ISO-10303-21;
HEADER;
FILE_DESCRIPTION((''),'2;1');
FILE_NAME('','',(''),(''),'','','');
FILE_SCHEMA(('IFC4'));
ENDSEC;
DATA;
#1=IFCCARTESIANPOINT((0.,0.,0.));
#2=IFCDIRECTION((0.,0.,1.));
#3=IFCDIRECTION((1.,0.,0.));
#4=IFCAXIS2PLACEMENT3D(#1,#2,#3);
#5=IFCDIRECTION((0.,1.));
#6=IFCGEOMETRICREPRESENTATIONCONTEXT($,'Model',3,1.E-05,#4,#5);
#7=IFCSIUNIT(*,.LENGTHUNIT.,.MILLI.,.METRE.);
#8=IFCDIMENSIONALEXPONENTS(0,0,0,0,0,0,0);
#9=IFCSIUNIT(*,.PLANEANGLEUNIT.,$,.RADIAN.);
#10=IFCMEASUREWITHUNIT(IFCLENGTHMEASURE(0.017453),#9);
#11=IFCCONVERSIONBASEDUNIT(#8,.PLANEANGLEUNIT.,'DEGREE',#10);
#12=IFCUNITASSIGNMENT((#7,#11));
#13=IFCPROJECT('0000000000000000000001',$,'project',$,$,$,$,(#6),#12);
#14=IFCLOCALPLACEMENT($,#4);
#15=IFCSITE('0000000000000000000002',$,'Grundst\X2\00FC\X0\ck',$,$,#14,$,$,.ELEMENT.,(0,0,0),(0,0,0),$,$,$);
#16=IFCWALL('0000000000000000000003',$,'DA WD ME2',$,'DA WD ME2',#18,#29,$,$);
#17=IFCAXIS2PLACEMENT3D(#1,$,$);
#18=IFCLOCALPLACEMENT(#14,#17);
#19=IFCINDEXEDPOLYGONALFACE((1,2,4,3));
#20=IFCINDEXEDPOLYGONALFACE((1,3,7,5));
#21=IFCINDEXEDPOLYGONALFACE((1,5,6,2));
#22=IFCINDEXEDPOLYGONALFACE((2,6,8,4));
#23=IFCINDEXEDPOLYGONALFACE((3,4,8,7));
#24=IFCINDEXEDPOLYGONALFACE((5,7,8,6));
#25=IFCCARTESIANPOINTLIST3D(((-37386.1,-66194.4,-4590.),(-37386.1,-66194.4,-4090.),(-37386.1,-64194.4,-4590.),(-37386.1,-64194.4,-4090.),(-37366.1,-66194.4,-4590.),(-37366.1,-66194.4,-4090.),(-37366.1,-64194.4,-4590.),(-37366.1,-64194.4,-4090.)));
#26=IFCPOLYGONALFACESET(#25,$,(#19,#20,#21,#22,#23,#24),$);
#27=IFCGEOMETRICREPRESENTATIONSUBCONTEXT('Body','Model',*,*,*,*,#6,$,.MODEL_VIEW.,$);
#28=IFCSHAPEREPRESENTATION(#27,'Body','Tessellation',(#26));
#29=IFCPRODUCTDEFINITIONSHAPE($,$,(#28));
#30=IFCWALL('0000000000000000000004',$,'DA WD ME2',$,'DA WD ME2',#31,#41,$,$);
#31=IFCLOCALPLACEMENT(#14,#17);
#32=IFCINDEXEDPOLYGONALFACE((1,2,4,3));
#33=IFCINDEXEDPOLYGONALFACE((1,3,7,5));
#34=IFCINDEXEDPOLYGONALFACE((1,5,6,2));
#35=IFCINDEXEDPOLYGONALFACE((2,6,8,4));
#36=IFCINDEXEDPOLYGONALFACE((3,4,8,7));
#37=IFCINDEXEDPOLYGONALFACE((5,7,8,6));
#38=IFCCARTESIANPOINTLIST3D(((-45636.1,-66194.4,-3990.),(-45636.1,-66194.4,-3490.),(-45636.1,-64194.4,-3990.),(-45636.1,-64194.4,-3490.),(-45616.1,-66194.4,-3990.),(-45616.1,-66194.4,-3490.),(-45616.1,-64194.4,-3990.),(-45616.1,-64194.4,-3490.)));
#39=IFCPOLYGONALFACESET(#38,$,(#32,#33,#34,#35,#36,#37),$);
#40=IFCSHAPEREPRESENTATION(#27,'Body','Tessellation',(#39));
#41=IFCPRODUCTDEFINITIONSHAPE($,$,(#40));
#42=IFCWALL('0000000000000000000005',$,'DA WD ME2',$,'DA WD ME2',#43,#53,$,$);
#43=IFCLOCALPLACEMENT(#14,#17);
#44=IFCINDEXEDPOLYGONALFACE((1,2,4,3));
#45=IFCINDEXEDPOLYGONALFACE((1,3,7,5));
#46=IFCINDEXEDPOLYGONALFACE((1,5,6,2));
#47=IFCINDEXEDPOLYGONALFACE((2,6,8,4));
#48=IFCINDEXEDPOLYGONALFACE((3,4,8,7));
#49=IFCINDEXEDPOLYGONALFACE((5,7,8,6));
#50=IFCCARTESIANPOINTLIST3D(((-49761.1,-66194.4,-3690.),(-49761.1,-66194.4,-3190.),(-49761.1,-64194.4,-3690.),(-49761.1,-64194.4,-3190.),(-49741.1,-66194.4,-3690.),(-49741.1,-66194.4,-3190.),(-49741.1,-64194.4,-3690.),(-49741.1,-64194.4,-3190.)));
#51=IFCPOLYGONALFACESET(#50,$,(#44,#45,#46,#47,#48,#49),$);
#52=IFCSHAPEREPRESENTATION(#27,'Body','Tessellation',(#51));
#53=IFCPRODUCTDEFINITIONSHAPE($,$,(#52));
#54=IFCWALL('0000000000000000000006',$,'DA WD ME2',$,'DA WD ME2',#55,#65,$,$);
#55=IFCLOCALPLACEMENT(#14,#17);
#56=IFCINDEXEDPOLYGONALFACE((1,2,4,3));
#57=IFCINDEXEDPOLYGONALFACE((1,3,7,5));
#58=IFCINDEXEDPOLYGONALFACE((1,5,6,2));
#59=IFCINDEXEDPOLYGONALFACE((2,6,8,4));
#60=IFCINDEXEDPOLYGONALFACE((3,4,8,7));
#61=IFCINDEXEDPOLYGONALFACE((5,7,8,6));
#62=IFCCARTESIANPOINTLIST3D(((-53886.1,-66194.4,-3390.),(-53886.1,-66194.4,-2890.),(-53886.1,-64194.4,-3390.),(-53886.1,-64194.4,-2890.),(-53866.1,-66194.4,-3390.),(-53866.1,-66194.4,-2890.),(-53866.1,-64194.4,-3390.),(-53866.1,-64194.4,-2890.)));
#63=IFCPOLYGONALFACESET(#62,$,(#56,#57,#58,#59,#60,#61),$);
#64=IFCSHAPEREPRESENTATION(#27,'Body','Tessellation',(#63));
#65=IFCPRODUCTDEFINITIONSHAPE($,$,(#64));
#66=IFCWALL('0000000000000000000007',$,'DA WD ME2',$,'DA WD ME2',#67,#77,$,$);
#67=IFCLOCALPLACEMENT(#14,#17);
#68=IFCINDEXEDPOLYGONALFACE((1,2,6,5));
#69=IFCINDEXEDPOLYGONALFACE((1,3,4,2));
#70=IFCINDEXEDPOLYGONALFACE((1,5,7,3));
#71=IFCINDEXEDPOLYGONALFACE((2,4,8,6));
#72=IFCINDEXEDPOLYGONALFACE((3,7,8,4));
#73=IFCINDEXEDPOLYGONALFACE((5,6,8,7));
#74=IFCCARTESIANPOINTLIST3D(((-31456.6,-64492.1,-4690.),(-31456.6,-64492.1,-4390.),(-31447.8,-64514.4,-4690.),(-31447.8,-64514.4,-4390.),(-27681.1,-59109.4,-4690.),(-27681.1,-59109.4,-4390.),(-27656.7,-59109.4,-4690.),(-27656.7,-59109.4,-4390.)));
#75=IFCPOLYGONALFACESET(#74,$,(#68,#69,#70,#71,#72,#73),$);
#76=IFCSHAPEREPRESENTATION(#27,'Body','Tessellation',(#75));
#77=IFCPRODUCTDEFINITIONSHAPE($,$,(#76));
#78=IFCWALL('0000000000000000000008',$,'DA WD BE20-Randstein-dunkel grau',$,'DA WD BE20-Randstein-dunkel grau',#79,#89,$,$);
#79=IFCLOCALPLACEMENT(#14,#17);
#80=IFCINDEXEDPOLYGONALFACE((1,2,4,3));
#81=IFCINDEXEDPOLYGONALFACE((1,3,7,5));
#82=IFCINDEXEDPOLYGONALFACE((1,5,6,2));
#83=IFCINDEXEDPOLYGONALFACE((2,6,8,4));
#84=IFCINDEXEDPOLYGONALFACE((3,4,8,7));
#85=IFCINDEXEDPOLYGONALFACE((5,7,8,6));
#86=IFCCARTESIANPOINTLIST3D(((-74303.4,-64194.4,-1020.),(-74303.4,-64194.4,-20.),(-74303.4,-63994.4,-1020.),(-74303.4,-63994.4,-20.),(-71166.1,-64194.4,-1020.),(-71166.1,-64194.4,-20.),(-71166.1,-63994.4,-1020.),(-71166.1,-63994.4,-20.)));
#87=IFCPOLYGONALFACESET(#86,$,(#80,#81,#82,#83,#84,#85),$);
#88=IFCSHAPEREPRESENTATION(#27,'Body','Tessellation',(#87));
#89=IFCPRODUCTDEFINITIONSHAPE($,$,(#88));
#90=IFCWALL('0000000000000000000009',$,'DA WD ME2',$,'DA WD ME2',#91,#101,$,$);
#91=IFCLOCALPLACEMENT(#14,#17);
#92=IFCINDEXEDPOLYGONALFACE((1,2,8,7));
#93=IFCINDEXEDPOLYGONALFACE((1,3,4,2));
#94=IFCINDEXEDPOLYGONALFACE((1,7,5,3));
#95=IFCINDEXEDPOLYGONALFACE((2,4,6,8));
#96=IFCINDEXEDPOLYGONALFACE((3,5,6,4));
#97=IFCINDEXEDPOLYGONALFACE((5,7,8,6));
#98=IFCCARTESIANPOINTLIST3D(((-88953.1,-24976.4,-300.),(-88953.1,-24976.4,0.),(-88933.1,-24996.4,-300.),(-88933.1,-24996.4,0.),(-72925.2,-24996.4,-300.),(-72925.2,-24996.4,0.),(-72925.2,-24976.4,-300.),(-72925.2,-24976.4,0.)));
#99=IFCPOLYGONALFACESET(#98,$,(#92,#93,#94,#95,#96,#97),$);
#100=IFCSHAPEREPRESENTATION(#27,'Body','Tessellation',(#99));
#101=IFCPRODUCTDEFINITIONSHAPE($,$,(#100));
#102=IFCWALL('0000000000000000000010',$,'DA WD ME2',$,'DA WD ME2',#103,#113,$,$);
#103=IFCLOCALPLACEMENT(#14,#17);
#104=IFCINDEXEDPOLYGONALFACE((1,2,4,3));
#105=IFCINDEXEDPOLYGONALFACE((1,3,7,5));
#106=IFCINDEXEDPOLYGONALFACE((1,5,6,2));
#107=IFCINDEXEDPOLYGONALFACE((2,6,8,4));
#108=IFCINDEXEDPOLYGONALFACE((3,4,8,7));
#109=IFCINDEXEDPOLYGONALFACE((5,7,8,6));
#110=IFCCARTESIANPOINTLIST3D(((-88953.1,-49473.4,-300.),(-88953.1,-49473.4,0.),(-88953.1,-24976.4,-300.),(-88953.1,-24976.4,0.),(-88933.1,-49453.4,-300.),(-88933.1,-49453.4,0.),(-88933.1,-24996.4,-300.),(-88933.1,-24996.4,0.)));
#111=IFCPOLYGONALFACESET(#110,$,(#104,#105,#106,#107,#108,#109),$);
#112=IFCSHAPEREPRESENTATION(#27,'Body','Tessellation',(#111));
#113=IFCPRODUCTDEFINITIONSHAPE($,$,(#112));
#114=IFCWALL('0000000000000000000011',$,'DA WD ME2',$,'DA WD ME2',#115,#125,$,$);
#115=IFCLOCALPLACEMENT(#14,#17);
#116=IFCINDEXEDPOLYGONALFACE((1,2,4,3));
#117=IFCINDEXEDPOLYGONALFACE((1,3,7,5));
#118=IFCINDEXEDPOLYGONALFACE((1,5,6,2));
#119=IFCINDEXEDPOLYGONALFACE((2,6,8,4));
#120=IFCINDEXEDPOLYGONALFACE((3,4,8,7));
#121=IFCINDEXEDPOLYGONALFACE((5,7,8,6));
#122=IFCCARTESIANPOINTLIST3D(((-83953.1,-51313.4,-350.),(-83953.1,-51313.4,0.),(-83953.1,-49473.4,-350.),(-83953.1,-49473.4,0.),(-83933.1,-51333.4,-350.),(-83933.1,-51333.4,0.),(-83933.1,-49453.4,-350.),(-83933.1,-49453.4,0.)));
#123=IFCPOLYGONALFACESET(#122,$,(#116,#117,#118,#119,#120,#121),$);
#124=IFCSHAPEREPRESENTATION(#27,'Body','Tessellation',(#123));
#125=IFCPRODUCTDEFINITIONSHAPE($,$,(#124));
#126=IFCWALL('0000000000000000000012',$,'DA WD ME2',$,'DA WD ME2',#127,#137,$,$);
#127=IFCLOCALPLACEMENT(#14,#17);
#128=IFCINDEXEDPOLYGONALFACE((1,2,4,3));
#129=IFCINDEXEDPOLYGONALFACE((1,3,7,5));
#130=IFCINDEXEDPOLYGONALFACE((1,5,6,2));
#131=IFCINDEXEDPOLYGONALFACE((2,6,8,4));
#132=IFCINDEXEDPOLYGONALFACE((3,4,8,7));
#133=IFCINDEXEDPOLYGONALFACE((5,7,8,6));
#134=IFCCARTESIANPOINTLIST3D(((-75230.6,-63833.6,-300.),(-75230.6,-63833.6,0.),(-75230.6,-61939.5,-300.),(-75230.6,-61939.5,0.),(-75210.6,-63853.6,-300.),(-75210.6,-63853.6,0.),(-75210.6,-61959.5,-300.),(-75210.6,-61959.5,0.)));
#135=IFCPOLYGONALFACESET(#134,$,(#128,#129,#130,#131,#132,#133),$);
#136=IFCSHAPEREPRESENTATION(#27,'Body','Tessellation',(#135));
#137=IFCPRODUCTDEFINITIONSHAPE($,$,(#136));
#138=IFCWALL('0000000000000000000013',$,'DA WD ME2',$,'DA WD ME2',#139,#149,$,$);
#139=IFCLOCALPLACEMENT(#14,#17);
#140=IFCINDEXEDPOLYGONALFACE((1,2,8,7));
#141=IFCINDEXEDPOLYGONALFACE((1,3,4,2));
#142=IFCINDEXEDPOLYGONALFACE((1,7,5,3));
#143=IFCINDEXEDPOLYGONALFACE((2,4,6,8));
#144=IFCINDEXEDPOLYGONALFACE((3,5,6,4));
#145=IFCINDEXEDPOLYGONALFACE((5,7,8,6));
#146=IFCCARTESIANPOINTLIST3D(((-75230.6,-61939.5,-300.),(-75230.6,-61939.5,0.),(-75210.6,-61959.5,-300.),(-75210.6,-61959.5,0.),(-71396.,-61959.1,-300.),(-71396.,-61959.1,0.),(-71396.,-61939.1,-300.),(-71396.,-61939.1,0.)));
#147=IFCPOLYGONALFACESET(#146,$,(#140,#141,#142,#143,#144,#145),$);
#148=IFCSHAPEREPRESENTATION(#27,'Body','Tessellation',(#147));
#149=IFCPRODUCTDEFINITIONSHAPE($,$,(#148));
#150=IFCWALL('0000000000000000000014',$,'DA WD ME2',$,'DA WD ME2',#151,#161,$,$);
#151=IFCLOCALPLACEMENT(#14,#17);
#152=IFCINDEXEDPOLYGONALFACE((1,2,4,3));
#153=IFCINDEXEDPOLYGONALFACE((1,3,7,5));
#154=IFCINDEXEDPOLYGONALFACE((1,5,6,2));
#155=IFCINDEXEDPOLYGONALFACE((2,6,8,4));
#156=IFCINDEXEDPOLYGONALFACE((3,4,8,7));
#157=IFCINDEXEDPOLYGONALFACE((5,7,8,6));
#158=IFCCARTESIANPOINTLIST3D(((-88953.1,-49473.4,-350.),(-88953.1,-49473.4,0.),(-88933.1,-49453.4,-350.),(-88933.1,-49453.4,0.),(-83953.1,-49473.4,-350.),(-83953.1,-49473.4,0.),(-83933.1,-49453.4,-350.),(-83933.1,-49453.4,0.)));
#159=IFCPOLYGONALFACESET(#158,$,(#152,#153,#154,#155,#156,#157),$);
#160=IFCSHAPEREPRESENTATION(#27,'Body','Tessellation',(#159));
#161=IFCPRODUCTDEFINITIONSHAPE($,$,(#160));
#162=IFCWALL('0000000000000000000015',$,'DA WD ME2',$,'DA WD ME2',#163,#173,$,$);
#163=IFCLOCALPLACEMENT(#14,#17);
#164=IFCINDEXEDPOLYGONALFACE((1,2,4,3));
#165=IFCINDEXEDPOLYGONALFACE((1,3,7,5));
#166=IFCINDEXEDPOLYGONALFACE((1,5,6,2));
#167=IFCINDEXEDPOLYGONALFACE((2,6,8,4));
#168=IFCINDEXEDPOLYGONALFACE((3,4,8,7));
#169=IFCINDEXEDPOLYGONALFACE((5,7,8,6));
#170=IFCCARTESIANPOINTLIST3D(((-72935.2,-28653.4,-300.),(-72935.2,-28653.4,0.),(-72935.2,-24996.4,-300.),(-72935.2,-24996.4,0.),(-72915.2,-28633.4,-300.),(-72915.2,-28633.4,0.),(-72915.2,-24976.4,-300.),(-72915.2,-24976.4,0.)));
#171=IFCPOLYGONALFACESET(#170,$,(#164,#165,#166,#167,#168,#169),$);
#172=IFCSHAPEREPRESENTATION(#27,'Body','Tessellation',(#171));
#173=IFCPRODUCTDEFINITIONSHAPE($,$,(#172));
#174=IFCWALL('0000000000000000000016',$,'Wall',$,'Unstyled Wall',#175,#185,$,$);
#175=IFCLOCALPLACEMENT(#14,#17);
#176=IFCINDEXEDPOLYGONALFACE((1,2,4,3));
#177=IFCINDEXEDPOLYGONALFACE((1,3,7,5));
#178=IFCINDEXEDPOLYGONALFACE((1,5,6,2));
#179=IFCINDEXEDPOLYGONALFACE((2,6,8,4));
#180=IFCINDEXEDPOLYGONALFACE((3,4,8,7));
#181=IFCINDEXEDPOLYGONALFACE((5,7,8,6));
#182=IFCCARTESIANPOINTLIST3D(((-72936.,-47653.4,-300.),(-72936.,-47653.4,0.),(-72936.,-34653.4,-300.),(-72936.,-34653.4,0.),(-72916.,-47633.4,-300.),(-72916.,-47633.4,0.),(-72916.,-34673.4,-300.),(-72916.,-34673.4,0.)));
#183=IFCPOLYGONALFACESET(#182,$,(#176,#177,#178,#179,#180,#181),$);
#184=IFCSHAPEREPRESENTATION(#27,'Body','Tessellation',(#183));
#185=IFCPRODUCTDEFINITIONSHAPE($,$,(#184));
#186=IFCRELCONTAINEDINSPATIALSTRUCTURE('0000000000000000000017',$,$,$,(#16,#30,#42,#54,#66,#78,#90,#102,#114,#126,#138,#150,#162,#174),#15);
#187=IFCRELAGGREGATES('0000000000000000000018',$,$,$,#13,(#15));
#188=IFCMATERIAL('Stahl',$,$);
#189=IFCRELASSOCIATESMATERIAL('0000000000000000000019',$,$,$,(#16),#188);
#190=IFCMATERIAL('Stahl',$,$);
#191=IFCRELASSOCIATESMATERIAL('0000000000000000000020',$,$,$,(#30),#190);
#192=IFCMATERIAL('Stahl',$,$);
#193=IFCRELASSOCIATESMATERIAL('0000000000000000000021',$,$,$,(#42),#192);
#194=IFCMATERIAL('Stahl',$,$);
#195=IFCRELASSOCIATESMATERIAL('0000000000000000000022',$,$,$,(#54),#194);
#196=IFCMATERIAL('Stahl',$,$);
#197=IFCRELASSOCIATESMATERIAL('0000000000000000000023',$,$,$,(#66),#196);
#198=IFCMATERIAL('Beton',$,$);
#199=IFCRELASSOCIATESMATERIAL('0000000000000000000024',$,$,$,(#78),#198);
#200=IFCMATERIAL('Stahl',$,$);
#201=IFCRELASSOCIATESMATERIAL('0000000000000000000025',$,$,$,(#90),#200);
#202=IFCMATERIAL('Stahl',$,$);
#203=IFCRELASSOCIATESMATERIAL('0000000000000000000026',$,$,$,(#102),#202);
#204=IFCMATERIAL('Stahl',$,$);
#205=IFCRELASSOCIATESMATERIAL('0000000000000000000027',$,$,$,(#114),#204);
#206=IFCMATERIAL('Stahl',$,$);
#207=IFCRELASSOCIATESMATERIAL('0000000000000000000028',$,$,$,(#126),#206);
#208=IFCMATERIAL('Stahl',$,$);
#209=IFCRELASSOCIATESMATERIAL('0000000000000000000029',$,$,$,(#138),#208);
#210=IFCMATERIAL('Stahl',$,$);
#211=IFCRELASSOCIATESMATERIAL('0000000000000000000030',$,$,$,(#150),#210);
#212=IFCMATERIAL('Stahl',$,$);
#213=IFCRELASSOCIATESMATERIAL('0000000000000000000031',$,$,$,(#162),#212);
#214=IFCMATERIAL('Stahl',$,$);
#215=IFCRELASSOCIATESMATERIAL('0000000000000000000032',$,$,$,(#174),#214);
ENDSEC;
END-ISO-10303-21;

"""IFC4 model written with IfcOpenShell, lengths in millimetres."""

from ifc_helpers import new_model, entity, si_unit, converted_unit, direction, frame, origin_with_axes, place, context, subcontext, project, spatial, line, indexed_curve, outline, extrude, material, element, save


model = new_model("IFC4")

# Units and contexts
model_context = context("Model", 3, precision=1e-05, world=origin_with_axes(), true_north=direction((0.0, 1.0)))
body_context = subcontext(model_context, "Body", "Model", "MODEL_VIEW")
ifc_project = project(units=[si_unit("LENGTHUNIT", "METRE", prefix="MILLI"), converted_unit("PLANEANGLEUNIT", "DEGREE", entity("IfcLengthMeasure", 0.017453), si_unit("PLANEANGLEUNIT", "RADIAN"), dimensions=[0, 0, 0, 0, 0, 0, 0])], contexts=[model_context])

# Site
site_placement = place(None, origin_with_axes())
site = spatial("IfcSite", under=ifc_project, at=site_placement, Name="Grundstück", CompositionType="ELEMENT", RefLatitude=(0, 0, 0), RefLongitude=(0, 0, 0))

# Walls
ifc_material_1 = material(Name="Stahl")
wall_1_placement = place(site_placement, frame((-37376.1, -64194.4, -4590.0), z_axis=(0.0, 0.0, 1.0), x_axis=(0.0, -1.0, 0.0)))
element("IfcWall", 1, at=wall_1_placement, inside=site, material=ifc_material_1, Name="DA WD ME2", ObjectType="DA WD ME2", context=body_context, shape_type="SweptSolid", body=[
    extrude(outline(indexed_curve([(0.0, -10.0), (0.0, 10.0), (2000.0, 10.0), (2000.0, -10.0)], segments=[line(1, 2), line(2, 3), line(3, 4), line(4, 1)])), origin_with_axes(), (0.0, 0.0, 1.0), 500.0),
])
ifc_material_2 = material(Name="Stahl")
wall_2_placement = place(site_placement, frame((-45626.1, -64194.4, -3990.0), z_axis=(0.0, 0.0, 1.0), x_axis=(0.0, -1.0, 0.0)))
element("IfcWall", 2, at=wall_2_placement, inside=site, material=ifc_material_2, Name="DA WD ME2", ObjectType="DA WD ME2", context=body_context, shape_type="SweptSolid", body=[
    extrude(outline(indexed_curve([(0.0, -10.0), (0.0, 10.0), (2000.0, 10.0), (2000.0, -10.0)], segments=[line(1, 2), line(2, 3), line(3, 4), line(4, 1)])), origin_with_axes(), (0.0, 0.0, 1.0), 500.0),
])
ifc_material_3 = material(Name="Stahl")
wall_3_placement = place(site_placement, frame((-49751.1, -64194.4, -3690.0), z_axis=(0.0, 0.0, 1.0), x_axis=(0.0, -1.0, 0.0)))
element("IfcWall", 3, at=wall_3_placement, inside=site, material=ifc_material_3, Name="DA WD ME2", ObjectType="DA WD ME2", context=body_context, shape_type="SweptSolid", body=[
    extrude(outline(indexed_curve([(0.0, -10.0), (0.0, 10.0), (2000.0, 10.0), (2000.0, -10.0)], segments=[line(1, 2), line(2, 3), line(3, 4), line(4, 1)])), origin_with_axes(), (0.0, 0.0, 1.0), 500.0),
])
ifc_material_4 = material(Name="Stahl")
wall_4_placement = place(site_placement, frame((-53876.1, -64194.4, -3390.0), z_axis=(0.0, 0.0, 1.0), x_axis=(0.0, -1.0, 0.0)))
element("IfcWall", 4, at=wall_4_placement, inside=site, material=ifc_material_4, Name="DA WD ME2", ObjectType="DA WD ME2", context=body_context, shape_type="SweptSolid", body=[
    extrude(outline(indexed_curve([(0.0, -10.0), (0.0, 10.0), (2000.0, 10.0), (2000.0, -10.0)], segments=[line(1, 2), line(2, 3), line(3, 4), line(4, 1)])), origin_with_axes(), (0.0, 0.0, 1.0), 500.0),
])
ifc_material_5 = material(Name="Stahl")
wall_5_placement = place(site_placement, frame((-31452.2, -64503.3, -4690.0), z_axis=(0.0, 0.0, 1.0), x_axis=(0.574238, 0.818689, 0.0)))
element("IfcWall", 5, at=wall_5_placement, inside=site, material=ifc_material_5, Name="DA WD ME2", ObjectType="DA WD ME2", context=body_context, shape_type="SweptSolid", body=[
    extrude(outline(indexed_curve([(-6.6, -10.0), (6.6, 10.0), (6581.4, 10.0), (6595.4, -10.0)], segments=[line(1, 2), line(2, 3), line(3, 4), line(4, 1)])), origin_with_axes(), (0.0, 0.0, 1.0), 300.0),
])
ifc_material_6 = material(Name="Beton")
wall_6_placement = place(site_placement, frame((-74303.4, -64094.4, -1020.0), z_axis=(0.0, 0.0, 1.0), x_axis=(1.0, -0.000018, 0.0)))
element("IfcWall", 6, at=wall_6_placement, inside=site, material=ifc_material_6, Name="DA WD BE20-Randstein-dunkel grau", ObjectType="DA WD BE20-Randstein-dunkel grau", context=body_context, shape_type="SweptSolid", body=[
    extrude(outline(indexed_curve([(0.0, 100.0), (0.0, -100.0), (3137.3, -100.0), (3137.3, 100.0)], segments=[line(1, 2), line(2, 3), line(3, 4), line(4, 1)])), origin_with_axes(), (0.0, 0.0, 1.0), 1000.0),
])
ifc_material_7 = material(Name="Stahl")
wall_7_placement = place(site_placement, frame((-72925.2, -24986.4, -300.0), z_axis=(0.0, 0.0, 1.0), x_axis=(-1.0, 0.0, 0.0)))
element("IfcWall", 7, at=wall_7_placement, inside=site, material=ifc_material_7, Name="DA WD ME2", ObjectType="DA WD ME2", context=body_context, shape_type="SweptSolid", body=[
    extrude(outline(indexed_curve([(0.0, -10.0), (0.0, 10.0), (16007.8, 10.0), (16027.8, -10.0)], segments=[line(1, 2), line(2, 3), line(3, 4), line(4, 1)])), origin_with_axes(), (0.0, 0.0, 1.0), 300.0),
])
ifc_material_8 = material(Name="Stahl")
wall_8_placement = place(site_placement, frame((-88943.1, -24986.4, -300.0), z_axis=(0.0, 0.0, 1.0), x_axis=(0.0, -1.0, 0.0)))
element("IfcWall", 8, at=wall_8_placement, inside=site, material=ifc_material_8, Name="DA WD ME2", ObjectType="DA WD ME2", context=body_context, shape_type="SweptSolid", body=[
    extrude(outline(indexed_curve([(-10.0, -10.0), (10.0, 10.0), (24467.1, 10.0), (24487.1, -10.0)], segments=[line(1, 2), line(2, 3), line(3, 4), line(4, 1)])), origin_with_axes(), (0.0, 0.0, 1.0), 300.0),
])
ifc_material_9 = material(Name="Stahl")
wall_9_placement = place(site_placement, frame((-83943.1, -49463.4, -350.0), z_axis=(0.0, 0.0, 1.0), x_axis=(0.0, -1.0, 0.0)))
element("IfcWall", 9, at=wall_9_placement, inside=site, material=ifc_material_9, Name="DA WD ME2", ObjectType="DA WD ME2", context=body_context, shape_type="SweptSolid", body=[
    extrude(outline(indexed_curve([(10.0, -10.0), (-10.0, 10.0), (1870.0, 10.0), (1850.0, -10.0)], segments=[line(1, 2), line(2, 3), line(3, 4), line(4, 1)])), origin_with_axes(), (0.0, 0.0, 1.0), 350.0),
])
ifc_material_10 = material(Name="Stahl")
wall_10_placement = place(site_placement, frame((-75220.6, -63843.6, -300.0), z_axis=(0.0, 0.0, 1.0), x_axis=(0.0, 1.0, 0.0)))
element("IfcWall", 10, at=wall_10_placement, inside=site, material=ifc_material_10, Name="DA WD ME2", ObjectType="DA WD ME2", context=body_context, shape_type="SweptSolid", body=[
    extrude(outline(indexed_curve([(10.0, 10.0), (-10.0, -10.0), (1884.1, -10.0), (1904.1, 10.0)], segments=[line(1, 2), line(2, 3), line(3, 4), line(4, 1)])), origin_with_axes(), (0.0, 0.0, 1.0), 300.0),
])
ifc_material_11 = material(Name="Stahl")
wall_11_placement = place(site_placement, frame((-75220.6, -61949.5, -300.0), z_axis=(0.0, 0.0, 1.0), x_axis=(1.0, 0.000125, 0.0)))
element("IfcWall", 11, at=wall_11_placement, inside=site, material=ifc_material_11, Name="DA WD ME2", ObjectType="DA WD ME2", context=body_context, shape_type="SweptSolid", body=[
    extrude(outline(indexed_curve([(10.0, -10.0), (-10.0, 10.0), (3824.6, 10.0), (3824.6, -10.0)], segments=[line(1, 2), line(2, 3), line(3, 4), line(4, 1)])), origin_with_axes(), (0.0, 0.0, 1.0), 300.0),
])
ifc_material_12 = material(Name="Stahl")
wall_12_placement = place(site_placement, frame((-88943.1, -49463.4, -350.0), z_axis=(0.0, 0.0, 1.0), x_axis=(1.0, 0.0, 0.0)))
element("IfcWall", 12, at=wall_12_placement, inside=site, material=ifc_material_12, Name="DA WD ME2", ObjectType="DA WD ME2", context=body_context, shape_type="SweptSolid", body=[
    extrude(outline(indexed_curve([(-10.0, -10.0), (10.0, 10.0), (5010.0, 10.0), (4990.0, -10.0)], segments=[line(1, 2), line(2, 3), line(3, 4), line(4, 1)])), origin_with_axes(), (0.0, 0.0, 1.0), 350.0),
])
ifc_material_13 = material(Name="Stahl")
wall_13_placement = place(site_placement, frame((-72925.2, -24986.4, -300.0), z_axis=(0.0, 0.0, 1.0), x_axis=(0.0, -1.0, 0.0)))
element("IfcWall", 13, at=wall_13_placement, inside=site, material=ifc_material_13, Name="DA WD ME2", ObjectType="DA WD ME2", context=body_context, shape_type="SweptSolid", body=[
    extrude(outline(indexed_curve([(10.0, -10.0), (-10.0, 10.0), (3647.1, 10.0), (3667.1, -10.0)], segments=[line(1, 2), line(2, 3), line(3, 4), line(4, 1)])), origin_with_axes(), (0.0, 0.0, 1.0), 300.0),
])
ifc_material_14 = material(Name="Stahl")
wall_14_placement = place(site_placement, frame((-72926.0, -34663.4, -300.0), z_axis=(0.0, 0.0, 1.0), x_axis=(0.0, -1.0, 0.0)))
element("IfcWall", 14, at=wall_14_placement, inside=site, material=ifc_material_14, Name="Wall", ObjectType="Unstyled Wall", context=body_context, shape_type="SweptSolid", body=[
    extrude(outline(indexed_curve([(-10.0, -10.0), (10.0, 10.0), (12970.0, 10.0), (12990.0, -10.0)], segments=[line(1, 2), line(2, 3), line(3, 4), line(4, 1)])), origin_with_axes(), (0.0, 0.0, 1.0), 300.0),
])

save(model, "model.ifc")
